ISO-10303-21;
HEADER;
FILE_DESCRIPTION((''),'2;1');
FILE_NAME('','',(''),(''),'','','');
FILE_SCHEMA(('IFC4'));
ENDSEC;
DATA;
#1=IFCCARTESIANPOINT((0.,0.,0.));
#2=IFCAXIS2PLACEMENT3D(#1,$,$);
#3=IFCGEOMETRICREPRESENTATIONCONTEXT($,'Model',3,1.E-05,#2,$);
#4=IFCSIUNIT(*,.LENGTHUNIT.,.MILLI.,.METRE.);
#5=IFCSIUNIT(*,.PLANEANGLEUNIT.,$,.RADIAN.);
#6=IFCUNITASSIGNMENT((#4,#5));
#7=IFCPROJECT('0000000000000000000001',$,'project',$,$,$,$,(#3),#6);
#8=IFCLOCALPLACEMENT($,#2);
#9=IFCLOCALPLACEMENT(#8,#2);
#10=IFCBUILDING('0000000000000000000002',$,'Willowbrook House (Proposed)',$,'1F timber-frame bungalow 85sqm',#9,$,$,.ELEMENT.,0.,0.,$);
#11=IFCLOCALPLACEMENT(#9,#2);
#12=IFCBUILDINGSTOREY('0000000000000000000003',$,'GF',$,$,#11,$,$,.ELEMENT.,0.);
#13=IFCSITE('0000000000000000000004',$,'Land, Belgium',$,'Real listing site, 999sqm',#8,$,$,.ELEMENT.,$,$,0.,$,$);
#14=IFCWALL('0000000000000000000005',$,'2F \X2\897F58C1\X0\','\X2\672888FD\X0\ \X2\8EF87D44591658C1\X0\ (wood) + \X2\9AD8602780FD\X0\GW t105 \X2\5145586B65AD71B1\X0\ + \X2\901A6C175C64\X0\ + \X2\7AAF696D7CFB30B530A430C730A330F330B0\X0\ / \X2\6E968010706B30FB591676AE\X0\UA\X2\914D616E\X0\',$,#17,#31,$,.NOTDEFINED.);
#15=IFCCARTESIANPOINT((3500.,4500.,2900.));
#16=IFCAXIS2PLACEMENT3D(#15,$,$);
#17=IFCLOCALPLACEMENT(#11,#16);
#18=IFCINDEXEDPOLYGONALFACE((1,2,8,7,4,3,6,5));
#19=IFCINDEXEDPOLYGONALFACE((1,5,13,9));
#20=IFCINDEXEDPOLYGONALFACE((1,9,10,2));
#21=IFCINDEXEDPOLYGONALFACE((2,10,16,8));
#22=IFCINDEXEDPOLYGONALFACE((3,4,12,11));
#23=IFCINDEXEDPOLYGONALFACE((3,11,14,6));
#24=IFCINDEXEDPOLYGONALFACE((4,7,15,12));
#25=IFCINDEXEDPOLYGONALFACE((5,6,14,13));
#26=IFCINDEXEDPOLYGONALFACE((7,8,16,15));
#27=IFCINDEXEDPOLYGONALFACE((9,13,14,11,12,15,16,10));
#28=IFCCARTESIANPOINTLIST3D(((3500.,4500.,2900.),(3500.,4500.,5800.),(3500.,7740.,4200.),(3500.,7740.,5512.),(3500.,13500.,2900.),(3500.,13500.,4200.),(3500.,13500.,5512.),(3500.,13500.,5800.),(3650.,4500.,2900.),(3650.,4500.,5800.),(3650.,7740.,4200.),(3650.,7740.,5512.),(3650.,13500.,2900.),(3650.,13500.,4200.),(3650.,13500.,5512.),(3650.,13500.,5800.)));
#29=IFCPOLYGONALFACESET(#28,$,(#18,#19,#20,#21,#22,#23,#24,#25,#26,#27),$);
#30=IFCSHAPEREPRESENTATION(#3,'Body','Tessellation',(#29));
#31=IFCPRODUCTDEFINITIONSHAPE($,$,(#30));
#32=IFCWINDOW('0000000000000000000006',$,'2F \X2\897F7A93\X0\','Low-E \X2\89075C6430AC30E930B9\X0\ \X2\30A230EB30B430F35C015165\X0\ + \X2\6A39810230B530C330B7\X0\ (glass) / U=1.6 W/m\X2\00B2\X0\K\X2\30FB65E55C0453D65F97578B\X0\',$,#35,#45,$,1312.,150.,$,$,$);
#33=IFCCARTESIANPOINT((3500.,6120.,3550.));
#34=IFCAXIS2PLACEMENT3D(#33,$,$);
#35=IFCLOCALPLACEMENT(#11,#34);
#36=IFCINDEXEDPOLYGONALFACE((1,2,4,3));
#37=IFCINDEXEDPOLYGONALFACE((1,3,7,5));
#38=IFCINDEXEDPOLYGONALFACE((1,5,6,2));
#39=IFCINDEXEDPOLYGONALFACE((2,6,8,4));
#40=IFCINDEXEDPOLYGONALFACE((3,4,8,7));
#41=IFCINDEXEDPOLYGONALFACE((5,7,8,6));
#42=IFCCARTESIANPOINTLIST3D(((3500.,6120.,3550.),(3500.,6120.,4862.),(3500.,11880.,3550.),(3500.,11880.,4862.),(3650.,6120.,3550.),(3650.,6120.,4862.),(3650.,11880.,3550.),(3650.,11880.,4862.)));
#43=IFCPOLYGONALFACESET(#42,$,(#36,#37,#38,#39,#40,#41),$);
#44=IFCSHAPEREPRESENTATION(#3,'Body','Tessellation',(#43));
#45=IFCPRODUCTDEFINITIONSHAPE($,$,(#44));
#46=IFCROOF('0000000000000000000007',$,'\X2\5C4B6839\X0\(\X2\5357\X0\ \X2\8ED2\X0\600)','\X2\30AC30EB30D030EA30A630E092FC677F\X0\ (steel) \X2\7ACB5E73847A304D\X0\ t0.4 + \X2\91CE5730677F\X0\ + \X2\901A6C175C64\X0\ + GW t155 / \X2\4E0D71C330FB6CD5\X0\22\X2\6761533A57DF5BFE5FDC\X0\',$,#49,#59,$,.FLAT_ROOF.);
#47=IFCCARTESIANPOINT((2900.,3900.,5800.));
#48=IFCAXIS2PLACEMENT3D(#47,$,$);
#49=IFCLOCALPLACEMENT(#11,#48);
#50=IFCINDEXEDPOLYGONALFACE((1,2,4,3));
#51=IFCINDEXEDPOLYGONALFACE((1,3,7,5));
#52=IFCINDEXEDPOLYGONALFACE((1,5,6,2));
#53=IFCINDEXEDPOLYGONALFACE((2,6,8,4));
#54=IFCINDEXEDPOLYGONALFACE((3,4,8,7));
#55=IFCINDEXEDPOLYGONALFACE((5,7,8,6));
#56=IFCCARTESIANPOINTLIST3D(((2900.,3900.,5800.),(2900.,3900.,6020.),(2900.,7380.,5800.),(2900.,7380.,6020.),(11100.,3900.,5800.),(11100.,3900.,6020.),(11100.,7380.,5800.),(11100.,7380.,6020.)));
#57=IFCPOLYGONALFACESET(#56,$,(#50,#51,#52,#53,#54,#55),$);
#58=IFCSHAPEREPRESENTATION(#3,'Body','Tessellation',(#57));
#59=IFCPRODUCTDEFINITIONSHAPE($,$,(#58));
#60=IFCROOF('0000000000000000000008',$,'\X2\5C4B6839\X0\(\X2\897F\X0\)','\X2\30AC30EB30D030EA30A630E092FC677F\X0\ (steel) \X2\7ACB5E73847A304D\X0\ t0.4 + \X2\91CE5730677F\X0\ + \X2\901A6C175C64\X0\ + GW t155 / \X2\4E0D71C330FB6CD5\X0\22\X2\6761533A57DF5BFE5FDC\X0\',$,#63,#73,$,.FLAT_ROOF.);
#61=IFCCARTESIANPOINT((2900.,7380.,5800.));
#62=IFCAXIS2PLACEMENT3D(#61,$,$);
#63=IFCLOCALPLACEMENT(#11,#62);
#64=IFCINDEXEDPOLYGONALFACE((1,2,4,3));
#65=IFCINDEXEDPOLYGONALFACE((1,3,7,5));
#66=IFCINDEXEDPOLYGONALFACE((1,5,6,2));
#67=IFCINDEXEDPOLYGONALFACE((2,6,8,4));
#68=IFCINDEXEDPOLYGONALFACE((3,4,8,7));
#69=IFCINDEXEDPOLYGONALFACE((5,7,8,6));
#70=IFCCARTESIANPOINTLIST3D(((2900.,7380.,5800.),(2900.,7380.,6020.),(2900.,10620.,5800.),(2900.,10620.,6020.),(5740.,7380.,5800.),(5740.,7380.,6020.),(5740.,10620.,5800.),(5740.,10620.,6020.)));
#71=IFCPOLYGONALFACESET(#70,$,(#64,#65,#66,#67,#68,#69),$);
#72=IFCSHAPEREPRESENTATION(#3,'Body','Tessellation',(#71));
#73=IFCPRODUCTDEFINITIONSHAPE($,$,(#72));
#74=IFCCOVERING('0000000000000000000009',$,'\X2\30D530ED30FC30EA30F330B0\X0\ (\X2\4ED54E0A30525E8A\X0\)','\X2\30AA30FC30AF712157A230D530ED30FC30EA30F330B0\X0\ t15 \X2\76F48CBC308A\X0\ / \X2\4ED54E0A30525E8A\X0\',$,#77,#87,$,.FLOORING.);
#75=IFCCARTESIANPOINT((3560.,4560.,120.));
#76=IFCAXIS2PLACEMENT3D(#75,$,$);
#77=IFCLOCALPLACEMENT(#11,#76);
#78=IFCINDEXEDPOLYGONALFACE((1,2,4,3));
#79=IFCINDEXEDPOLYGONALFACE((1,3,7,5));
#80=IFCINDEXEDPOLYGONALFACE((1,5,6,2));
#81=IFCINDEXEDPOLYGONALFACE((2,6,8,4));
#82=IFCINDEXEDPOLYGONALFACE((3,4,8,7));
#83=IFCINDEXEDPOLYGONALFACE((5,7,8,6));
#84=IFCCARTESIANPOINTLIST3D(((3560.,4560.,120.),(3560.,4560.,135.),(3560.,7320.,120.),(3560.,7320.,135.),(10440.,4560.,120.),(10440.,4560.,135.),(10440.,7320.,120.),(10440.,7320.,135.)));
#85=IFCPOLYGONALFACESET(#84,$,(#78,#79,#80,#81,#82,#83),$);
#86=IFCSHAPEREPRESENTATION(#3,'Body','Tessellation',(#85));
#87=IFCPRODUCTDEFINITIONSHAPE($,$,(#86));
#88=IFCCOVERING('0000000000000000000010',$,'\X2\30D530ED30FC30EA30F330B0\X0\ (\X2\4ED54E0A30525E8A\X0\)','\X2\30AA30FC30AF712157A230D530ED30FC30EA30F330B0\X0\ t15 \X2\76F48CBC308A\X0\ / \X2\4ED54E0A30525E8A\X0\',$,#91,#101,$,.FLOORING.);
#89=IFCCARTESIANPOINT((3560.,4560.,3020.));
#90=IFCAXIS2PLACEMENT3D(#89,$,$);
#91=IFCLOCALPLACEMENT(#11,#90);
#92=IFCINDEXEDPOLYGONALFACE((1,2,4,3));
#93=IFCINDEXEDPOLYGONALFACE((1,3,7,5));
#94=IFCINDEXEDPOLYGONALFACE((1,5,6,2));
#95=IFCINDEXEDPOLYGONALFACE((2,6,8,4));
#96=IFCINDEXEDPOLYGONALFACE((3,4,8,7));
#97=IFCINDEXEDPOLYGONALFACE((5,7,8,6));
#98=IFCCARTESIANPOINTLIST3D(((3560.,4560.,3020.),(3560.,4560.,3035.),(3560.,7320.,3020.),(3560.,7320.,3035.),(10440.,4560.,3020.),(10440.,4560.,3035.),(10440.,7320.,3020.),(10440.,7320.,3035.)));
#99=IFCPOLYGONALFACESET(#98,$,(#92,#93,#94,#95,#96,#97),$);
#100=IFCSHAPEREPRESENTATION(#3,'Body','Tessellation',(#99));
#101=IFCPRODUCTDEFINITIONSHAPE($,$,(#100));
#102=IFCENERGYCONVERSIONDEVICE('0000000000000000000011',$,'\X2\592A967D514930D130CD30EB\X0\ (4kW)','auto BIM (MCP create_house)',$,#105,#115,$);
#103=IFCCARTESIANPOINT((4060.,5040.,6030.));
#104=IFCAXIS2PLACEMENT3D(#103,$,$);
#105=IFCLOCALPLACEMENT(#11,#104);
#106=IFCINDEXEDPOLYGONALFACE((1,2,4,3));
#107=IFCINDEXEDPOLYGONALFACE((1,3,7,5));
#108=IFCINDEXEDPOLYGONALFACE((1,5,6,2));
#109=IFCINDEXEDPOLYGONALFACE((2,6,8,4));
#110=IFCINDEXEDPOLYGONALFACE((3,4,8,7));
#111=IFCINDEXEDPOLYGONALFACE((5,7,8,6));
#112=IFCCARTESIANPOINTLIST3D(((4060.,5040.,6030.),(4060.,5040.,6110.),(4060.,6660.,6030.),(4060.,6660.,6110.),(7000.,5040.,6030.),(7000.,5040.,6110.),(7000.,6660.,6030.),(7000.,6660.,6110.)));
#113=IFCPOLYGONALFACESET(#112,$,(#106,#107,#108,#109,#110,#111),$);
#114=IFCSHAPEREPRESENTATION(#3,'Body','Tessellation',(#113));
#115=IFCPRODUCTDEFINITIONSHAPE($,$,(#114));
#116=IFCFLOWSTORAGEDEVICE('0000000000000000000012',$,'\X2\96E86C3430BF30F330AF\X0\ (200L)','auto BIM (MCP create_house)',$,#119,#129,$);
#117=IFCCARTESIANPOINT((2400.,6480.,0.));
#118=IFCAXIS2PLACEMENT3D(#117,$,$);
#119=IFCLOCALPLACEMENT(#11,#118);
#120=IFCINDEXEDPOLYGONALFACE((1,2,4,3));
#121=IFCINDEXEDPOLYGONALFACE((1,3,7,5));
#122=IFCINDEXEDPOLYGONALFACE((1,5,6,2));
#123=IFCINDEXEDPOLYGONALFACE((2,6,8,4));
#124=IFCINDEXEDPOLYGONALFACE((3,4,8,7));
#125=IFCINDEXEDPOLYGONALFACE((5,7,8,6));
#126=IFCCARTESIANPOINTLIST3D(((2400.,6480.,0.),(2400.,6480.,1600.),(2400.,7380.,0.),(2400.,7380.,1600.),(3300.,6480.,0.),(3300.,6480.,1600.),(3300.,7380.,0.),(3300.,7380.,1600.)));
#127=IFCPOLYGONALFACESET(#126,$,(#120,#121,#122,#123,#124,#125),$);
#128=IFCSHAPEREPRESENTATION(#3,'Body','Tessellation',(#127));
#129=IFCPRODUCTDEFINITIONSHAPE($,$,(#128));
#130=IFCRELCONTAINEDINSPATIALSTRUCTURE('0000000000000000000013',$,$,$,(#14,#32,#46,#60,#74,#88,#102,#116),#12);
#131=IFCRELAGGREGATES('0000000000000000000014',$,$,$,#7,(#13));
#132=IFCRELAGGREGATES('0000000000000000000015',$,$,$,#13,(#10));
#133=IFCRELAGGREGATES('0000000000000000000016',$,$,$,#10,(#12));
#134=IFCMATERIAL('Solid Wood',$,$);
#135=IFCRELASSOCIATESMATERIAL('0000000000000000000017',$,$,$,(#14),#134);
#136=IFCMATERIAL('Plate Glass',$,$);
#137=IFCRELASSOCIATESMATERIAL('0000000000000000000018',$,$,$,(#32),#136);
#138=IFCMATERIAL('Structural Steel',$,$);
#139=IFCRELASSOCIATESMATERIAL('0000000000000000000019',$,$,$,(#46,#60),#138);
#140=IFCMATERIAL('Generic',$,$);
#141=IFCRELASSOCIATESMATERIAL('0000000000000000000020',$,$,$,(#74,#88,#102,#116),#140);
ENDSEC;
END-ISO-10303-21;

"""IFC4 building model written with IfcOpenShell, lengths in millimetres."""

from ifc_helpers import new_model, si_unit, frame, frame_2d, origin, place, context, project, spatial, rectangle, extrude, material, element, fill, save


model = new_model("IFC4")

# Units and contexts
model_context = context("Model", 3, precision=1e-05, world=origin())
ifc_project = project(units=[si_unit("LENGTHUNIT", "METRE", prefix="MILLI"), si_unit("PLANEANGLEUNIT", "RADIAN")], contexts=[model_context])

# Site, building, storey
site_placement = place(None, origin())
site = spatial("IfcSite", under=ifc_project, at=site_placement, Name="Land, Belgium", ObjectType="Real listing site, 999sqm", CompositionType="ELEMENT", RefElevation=0.0)
building_placement = place(site_placement, origin())
building = spatial("IfcBuilding", under=site, at=building_placement, Name="Willowbrook House (Proposed)", ObjectType="1F timber-frame bungalow 85sqm", CompositionType="ELEMENT", ElevationOfRefHeight=0.0, ElevationOfTerrain=0.0)
storey_placement = place(building_placement, origin())
storey = spatial("IfcBuildingStorey", under=building, at=storey_placement, Name="GF", CompositionType="ELEMENT", Elevation=0.0)

# Shared definitions
ifc_material_1 = material(Name="Solid Wood")
ifc_material_2 = material(Name="Generic")

# Shared definitions
ifc_material_3 = material(Name="Plate Glass")

# Wall, opening, window
wall_1_placement = place(storey_placement, frame((3500.0, 4500.0, 2900.0)))
wall_1 = element("IfcWall", 1, at=wall_1_placement, inside=storey, material=ifc_material_1, Name="2F 西壁", Description="木製 軸組外壁 (wood) + 高性能GW t105 充填断熱 + 通気層 + 窯業系サイディング / 準耐火・外皮UA配慮", PredefinedType="NOTDEFINED", context=model_context, shape_type="SweptSolid", body=[
    extrude(rectangle(XDim=150.0, YDim=9000.0, at=frame_2d((75.0, 4500.0))), frame((3500.0, 4500.0, 2900.0)), (0.0, 0.0, 1.0), 2900.0),
])
opening_1_placement = place(storey_placement, frame((3500.0, 6120.0, 3550.0)))
opening_1 = element("IfcOpeningElement", 2, at=opening_1_placement, cuts=wall_1, PredefinedType="NOTDEFINED", context=model_context, shape_type="SweptSolid", body=[
    extrude(rectangle(XDim=150.0, YDim=5760.0, at=frame_2d((75.0, 2880.0))), frame((3500.0, 6120.0, 3550.0)), (0.0, 0.0, 1.0), 1312.0),
])
window_1_placement = place(storey_placement, frame((3500.0, 6120.0, 3550.0)))
window_1 = element("IfcWindow", 3, at=window_1_placement, inside=storey, material=ifc_material_3, Name="2F 西窓", Description="Low-E 複層ガラス アルゴン封入 + 樹脂サッシ (glass) / U=1.6 W/m²K・日射取得型", OverallHeight=1312.0, OverallWidth=150.0, context=model_context, shape_type="SweptSolid", body=[
    extrude(rectangle(XDim=150.0, YDim=5760.0, at=frame_2d((75.0, 2880.0))), frame((3500.0, 6120.0, 3550.0)), (0.0, 0.0, 1.0), 1312.0),
])
fill(opening_1, window_1)

# Roofs
ifc_material_4 = material(Name="Structural Steel")
roof_1_placement = place(storey_placement, frame((2900.0, 3900.0, 5800.0)))
element("IfcRoof", 4, at=roof_1_placement, inside=storey, material=ifc_material_4, Name="屋根(南 軒600)", Description="ガルバリウム鋼板 (steel) 立平葺き t0.4 + 野地板 + 通気層 + GW t155 / 不燃・法22条区域対応", PredefinedType="FLAT_ROOF", context=model_context, shape_type="SweptSolid", body=[
    extrude(rectangle(XDim=8200.0, YDim=3480.0, at=frame_2d((4100.0, 1740.0))), frame((2900.0, 3900.0, 5800.0)), (0.0, 0.0, 1.0), 220.0),
])
roof_2_placement = place(storey_placement, frame((2900.0, 7380.0, 5800.0)))
element("IfcRoof", 5, at=roof_2_placement, inside=storey, material=ifc_material_4, Name="屋根(西)", Description="ガルバリウム鋼板 (steel) 立平葺き t0.4 + 野地板 + 通気層 + GW t155 / 不燃・法22条区域対応", PredefinedType="FLAT_ROOF", context=model_context, shape_type="SweptSolid", body=[
    extrude(rectangle(XDim=2840.0, YDim=3240.0, at=frame_2d((1420.0, 1620.0))), frame((2900.0, 7380.0, 5800.0)), (0.0, 0.0, 1.0), 220.0),
])

# Coverings
covering_1_placement = place(storey_placement, frame((3560.0, 4560.0, 120.0)))
element("IfcCovering", 6, at=covering_1_placement, inside=storey, material=ifc_material_2, Name="フローリング (仕上げ床)", Description="オーク無垢フローリング t15 直貼り / 仕上げ床", PredefinedType="FLOORING", context=model_context, shape_type="SweptSolid", body=[
    extrude(rectangle(XDim=6880.0, YDim=2760.0, at=frame_2d((3440.0, 1380.0))), frame((3560.0, 4560.0, 120.0)), (0.0, 0.0, 1.0), 15.0),
])
covering_2_placement = place(storey_placement, frame((3560.0, 4560.0, 3020.0)))
element("IfcCovering", 7, at=covering_2_placement, inside=storey, material=ifc_material_2, Name="フローリング (仕上げ床)", Description="オーク無垢フローリング t15 直貼り / 仕上げ床", PredefinedType="FLOORING", context=model_context, shape_type="SweptSolid", body=[
    extrude(rectangle(XDim=6880.0, YDim=2760.0, at=frame_2d((3440.0, 1380.0))), frame((3560.0, 4560.0, 3020.0)), (0.0, 0.0, 1.0), 15.0),
])

# Energy conversion device
energy_conversion_device_placement = place(storey_placement, frame((4060.0, 5040.0, 6030.0)))
element("IfcEnergyConversionDevice", 8, at=energy_conversion_device_placement, inside=storey, material=ifc_material_2, Name="太陽光パネル (4kW)", Description="auto BIM (MCP create_house)", context=model_context, shape_type="SweptSolid", body=[
    extrude(rectangle(XDim=2940.0, YDim=1620.0, at=frame_2d((1470.0, 810.0))), frame((4060.0, 5040.0, 6030.0)), (0.0, 0.0, 1.0), 80.0),
])

# Flow storage device
flow_storage_device_placement = place(storey_placement, frame((2400.0, 6480.0, 0.0)))
element("IfcFlowStorageDevice", 9, at=flow_storage_device_placement, inside=storey, material=ifc_material_2, Name="雨水タンク (200L)", Description="auto BIM (MCP create_house)", context=model_context, shape_type="SweptSolid", body=[
    extrude(rectangle(XDim=900.0, YDim=900.0, at=frame_2d((450.0, 450.0))), frame((2400.0, 6480.0, 0.0)), (0.0, 0.0, 1.0), 1600.0),
])

save(model, "model.ifc")
